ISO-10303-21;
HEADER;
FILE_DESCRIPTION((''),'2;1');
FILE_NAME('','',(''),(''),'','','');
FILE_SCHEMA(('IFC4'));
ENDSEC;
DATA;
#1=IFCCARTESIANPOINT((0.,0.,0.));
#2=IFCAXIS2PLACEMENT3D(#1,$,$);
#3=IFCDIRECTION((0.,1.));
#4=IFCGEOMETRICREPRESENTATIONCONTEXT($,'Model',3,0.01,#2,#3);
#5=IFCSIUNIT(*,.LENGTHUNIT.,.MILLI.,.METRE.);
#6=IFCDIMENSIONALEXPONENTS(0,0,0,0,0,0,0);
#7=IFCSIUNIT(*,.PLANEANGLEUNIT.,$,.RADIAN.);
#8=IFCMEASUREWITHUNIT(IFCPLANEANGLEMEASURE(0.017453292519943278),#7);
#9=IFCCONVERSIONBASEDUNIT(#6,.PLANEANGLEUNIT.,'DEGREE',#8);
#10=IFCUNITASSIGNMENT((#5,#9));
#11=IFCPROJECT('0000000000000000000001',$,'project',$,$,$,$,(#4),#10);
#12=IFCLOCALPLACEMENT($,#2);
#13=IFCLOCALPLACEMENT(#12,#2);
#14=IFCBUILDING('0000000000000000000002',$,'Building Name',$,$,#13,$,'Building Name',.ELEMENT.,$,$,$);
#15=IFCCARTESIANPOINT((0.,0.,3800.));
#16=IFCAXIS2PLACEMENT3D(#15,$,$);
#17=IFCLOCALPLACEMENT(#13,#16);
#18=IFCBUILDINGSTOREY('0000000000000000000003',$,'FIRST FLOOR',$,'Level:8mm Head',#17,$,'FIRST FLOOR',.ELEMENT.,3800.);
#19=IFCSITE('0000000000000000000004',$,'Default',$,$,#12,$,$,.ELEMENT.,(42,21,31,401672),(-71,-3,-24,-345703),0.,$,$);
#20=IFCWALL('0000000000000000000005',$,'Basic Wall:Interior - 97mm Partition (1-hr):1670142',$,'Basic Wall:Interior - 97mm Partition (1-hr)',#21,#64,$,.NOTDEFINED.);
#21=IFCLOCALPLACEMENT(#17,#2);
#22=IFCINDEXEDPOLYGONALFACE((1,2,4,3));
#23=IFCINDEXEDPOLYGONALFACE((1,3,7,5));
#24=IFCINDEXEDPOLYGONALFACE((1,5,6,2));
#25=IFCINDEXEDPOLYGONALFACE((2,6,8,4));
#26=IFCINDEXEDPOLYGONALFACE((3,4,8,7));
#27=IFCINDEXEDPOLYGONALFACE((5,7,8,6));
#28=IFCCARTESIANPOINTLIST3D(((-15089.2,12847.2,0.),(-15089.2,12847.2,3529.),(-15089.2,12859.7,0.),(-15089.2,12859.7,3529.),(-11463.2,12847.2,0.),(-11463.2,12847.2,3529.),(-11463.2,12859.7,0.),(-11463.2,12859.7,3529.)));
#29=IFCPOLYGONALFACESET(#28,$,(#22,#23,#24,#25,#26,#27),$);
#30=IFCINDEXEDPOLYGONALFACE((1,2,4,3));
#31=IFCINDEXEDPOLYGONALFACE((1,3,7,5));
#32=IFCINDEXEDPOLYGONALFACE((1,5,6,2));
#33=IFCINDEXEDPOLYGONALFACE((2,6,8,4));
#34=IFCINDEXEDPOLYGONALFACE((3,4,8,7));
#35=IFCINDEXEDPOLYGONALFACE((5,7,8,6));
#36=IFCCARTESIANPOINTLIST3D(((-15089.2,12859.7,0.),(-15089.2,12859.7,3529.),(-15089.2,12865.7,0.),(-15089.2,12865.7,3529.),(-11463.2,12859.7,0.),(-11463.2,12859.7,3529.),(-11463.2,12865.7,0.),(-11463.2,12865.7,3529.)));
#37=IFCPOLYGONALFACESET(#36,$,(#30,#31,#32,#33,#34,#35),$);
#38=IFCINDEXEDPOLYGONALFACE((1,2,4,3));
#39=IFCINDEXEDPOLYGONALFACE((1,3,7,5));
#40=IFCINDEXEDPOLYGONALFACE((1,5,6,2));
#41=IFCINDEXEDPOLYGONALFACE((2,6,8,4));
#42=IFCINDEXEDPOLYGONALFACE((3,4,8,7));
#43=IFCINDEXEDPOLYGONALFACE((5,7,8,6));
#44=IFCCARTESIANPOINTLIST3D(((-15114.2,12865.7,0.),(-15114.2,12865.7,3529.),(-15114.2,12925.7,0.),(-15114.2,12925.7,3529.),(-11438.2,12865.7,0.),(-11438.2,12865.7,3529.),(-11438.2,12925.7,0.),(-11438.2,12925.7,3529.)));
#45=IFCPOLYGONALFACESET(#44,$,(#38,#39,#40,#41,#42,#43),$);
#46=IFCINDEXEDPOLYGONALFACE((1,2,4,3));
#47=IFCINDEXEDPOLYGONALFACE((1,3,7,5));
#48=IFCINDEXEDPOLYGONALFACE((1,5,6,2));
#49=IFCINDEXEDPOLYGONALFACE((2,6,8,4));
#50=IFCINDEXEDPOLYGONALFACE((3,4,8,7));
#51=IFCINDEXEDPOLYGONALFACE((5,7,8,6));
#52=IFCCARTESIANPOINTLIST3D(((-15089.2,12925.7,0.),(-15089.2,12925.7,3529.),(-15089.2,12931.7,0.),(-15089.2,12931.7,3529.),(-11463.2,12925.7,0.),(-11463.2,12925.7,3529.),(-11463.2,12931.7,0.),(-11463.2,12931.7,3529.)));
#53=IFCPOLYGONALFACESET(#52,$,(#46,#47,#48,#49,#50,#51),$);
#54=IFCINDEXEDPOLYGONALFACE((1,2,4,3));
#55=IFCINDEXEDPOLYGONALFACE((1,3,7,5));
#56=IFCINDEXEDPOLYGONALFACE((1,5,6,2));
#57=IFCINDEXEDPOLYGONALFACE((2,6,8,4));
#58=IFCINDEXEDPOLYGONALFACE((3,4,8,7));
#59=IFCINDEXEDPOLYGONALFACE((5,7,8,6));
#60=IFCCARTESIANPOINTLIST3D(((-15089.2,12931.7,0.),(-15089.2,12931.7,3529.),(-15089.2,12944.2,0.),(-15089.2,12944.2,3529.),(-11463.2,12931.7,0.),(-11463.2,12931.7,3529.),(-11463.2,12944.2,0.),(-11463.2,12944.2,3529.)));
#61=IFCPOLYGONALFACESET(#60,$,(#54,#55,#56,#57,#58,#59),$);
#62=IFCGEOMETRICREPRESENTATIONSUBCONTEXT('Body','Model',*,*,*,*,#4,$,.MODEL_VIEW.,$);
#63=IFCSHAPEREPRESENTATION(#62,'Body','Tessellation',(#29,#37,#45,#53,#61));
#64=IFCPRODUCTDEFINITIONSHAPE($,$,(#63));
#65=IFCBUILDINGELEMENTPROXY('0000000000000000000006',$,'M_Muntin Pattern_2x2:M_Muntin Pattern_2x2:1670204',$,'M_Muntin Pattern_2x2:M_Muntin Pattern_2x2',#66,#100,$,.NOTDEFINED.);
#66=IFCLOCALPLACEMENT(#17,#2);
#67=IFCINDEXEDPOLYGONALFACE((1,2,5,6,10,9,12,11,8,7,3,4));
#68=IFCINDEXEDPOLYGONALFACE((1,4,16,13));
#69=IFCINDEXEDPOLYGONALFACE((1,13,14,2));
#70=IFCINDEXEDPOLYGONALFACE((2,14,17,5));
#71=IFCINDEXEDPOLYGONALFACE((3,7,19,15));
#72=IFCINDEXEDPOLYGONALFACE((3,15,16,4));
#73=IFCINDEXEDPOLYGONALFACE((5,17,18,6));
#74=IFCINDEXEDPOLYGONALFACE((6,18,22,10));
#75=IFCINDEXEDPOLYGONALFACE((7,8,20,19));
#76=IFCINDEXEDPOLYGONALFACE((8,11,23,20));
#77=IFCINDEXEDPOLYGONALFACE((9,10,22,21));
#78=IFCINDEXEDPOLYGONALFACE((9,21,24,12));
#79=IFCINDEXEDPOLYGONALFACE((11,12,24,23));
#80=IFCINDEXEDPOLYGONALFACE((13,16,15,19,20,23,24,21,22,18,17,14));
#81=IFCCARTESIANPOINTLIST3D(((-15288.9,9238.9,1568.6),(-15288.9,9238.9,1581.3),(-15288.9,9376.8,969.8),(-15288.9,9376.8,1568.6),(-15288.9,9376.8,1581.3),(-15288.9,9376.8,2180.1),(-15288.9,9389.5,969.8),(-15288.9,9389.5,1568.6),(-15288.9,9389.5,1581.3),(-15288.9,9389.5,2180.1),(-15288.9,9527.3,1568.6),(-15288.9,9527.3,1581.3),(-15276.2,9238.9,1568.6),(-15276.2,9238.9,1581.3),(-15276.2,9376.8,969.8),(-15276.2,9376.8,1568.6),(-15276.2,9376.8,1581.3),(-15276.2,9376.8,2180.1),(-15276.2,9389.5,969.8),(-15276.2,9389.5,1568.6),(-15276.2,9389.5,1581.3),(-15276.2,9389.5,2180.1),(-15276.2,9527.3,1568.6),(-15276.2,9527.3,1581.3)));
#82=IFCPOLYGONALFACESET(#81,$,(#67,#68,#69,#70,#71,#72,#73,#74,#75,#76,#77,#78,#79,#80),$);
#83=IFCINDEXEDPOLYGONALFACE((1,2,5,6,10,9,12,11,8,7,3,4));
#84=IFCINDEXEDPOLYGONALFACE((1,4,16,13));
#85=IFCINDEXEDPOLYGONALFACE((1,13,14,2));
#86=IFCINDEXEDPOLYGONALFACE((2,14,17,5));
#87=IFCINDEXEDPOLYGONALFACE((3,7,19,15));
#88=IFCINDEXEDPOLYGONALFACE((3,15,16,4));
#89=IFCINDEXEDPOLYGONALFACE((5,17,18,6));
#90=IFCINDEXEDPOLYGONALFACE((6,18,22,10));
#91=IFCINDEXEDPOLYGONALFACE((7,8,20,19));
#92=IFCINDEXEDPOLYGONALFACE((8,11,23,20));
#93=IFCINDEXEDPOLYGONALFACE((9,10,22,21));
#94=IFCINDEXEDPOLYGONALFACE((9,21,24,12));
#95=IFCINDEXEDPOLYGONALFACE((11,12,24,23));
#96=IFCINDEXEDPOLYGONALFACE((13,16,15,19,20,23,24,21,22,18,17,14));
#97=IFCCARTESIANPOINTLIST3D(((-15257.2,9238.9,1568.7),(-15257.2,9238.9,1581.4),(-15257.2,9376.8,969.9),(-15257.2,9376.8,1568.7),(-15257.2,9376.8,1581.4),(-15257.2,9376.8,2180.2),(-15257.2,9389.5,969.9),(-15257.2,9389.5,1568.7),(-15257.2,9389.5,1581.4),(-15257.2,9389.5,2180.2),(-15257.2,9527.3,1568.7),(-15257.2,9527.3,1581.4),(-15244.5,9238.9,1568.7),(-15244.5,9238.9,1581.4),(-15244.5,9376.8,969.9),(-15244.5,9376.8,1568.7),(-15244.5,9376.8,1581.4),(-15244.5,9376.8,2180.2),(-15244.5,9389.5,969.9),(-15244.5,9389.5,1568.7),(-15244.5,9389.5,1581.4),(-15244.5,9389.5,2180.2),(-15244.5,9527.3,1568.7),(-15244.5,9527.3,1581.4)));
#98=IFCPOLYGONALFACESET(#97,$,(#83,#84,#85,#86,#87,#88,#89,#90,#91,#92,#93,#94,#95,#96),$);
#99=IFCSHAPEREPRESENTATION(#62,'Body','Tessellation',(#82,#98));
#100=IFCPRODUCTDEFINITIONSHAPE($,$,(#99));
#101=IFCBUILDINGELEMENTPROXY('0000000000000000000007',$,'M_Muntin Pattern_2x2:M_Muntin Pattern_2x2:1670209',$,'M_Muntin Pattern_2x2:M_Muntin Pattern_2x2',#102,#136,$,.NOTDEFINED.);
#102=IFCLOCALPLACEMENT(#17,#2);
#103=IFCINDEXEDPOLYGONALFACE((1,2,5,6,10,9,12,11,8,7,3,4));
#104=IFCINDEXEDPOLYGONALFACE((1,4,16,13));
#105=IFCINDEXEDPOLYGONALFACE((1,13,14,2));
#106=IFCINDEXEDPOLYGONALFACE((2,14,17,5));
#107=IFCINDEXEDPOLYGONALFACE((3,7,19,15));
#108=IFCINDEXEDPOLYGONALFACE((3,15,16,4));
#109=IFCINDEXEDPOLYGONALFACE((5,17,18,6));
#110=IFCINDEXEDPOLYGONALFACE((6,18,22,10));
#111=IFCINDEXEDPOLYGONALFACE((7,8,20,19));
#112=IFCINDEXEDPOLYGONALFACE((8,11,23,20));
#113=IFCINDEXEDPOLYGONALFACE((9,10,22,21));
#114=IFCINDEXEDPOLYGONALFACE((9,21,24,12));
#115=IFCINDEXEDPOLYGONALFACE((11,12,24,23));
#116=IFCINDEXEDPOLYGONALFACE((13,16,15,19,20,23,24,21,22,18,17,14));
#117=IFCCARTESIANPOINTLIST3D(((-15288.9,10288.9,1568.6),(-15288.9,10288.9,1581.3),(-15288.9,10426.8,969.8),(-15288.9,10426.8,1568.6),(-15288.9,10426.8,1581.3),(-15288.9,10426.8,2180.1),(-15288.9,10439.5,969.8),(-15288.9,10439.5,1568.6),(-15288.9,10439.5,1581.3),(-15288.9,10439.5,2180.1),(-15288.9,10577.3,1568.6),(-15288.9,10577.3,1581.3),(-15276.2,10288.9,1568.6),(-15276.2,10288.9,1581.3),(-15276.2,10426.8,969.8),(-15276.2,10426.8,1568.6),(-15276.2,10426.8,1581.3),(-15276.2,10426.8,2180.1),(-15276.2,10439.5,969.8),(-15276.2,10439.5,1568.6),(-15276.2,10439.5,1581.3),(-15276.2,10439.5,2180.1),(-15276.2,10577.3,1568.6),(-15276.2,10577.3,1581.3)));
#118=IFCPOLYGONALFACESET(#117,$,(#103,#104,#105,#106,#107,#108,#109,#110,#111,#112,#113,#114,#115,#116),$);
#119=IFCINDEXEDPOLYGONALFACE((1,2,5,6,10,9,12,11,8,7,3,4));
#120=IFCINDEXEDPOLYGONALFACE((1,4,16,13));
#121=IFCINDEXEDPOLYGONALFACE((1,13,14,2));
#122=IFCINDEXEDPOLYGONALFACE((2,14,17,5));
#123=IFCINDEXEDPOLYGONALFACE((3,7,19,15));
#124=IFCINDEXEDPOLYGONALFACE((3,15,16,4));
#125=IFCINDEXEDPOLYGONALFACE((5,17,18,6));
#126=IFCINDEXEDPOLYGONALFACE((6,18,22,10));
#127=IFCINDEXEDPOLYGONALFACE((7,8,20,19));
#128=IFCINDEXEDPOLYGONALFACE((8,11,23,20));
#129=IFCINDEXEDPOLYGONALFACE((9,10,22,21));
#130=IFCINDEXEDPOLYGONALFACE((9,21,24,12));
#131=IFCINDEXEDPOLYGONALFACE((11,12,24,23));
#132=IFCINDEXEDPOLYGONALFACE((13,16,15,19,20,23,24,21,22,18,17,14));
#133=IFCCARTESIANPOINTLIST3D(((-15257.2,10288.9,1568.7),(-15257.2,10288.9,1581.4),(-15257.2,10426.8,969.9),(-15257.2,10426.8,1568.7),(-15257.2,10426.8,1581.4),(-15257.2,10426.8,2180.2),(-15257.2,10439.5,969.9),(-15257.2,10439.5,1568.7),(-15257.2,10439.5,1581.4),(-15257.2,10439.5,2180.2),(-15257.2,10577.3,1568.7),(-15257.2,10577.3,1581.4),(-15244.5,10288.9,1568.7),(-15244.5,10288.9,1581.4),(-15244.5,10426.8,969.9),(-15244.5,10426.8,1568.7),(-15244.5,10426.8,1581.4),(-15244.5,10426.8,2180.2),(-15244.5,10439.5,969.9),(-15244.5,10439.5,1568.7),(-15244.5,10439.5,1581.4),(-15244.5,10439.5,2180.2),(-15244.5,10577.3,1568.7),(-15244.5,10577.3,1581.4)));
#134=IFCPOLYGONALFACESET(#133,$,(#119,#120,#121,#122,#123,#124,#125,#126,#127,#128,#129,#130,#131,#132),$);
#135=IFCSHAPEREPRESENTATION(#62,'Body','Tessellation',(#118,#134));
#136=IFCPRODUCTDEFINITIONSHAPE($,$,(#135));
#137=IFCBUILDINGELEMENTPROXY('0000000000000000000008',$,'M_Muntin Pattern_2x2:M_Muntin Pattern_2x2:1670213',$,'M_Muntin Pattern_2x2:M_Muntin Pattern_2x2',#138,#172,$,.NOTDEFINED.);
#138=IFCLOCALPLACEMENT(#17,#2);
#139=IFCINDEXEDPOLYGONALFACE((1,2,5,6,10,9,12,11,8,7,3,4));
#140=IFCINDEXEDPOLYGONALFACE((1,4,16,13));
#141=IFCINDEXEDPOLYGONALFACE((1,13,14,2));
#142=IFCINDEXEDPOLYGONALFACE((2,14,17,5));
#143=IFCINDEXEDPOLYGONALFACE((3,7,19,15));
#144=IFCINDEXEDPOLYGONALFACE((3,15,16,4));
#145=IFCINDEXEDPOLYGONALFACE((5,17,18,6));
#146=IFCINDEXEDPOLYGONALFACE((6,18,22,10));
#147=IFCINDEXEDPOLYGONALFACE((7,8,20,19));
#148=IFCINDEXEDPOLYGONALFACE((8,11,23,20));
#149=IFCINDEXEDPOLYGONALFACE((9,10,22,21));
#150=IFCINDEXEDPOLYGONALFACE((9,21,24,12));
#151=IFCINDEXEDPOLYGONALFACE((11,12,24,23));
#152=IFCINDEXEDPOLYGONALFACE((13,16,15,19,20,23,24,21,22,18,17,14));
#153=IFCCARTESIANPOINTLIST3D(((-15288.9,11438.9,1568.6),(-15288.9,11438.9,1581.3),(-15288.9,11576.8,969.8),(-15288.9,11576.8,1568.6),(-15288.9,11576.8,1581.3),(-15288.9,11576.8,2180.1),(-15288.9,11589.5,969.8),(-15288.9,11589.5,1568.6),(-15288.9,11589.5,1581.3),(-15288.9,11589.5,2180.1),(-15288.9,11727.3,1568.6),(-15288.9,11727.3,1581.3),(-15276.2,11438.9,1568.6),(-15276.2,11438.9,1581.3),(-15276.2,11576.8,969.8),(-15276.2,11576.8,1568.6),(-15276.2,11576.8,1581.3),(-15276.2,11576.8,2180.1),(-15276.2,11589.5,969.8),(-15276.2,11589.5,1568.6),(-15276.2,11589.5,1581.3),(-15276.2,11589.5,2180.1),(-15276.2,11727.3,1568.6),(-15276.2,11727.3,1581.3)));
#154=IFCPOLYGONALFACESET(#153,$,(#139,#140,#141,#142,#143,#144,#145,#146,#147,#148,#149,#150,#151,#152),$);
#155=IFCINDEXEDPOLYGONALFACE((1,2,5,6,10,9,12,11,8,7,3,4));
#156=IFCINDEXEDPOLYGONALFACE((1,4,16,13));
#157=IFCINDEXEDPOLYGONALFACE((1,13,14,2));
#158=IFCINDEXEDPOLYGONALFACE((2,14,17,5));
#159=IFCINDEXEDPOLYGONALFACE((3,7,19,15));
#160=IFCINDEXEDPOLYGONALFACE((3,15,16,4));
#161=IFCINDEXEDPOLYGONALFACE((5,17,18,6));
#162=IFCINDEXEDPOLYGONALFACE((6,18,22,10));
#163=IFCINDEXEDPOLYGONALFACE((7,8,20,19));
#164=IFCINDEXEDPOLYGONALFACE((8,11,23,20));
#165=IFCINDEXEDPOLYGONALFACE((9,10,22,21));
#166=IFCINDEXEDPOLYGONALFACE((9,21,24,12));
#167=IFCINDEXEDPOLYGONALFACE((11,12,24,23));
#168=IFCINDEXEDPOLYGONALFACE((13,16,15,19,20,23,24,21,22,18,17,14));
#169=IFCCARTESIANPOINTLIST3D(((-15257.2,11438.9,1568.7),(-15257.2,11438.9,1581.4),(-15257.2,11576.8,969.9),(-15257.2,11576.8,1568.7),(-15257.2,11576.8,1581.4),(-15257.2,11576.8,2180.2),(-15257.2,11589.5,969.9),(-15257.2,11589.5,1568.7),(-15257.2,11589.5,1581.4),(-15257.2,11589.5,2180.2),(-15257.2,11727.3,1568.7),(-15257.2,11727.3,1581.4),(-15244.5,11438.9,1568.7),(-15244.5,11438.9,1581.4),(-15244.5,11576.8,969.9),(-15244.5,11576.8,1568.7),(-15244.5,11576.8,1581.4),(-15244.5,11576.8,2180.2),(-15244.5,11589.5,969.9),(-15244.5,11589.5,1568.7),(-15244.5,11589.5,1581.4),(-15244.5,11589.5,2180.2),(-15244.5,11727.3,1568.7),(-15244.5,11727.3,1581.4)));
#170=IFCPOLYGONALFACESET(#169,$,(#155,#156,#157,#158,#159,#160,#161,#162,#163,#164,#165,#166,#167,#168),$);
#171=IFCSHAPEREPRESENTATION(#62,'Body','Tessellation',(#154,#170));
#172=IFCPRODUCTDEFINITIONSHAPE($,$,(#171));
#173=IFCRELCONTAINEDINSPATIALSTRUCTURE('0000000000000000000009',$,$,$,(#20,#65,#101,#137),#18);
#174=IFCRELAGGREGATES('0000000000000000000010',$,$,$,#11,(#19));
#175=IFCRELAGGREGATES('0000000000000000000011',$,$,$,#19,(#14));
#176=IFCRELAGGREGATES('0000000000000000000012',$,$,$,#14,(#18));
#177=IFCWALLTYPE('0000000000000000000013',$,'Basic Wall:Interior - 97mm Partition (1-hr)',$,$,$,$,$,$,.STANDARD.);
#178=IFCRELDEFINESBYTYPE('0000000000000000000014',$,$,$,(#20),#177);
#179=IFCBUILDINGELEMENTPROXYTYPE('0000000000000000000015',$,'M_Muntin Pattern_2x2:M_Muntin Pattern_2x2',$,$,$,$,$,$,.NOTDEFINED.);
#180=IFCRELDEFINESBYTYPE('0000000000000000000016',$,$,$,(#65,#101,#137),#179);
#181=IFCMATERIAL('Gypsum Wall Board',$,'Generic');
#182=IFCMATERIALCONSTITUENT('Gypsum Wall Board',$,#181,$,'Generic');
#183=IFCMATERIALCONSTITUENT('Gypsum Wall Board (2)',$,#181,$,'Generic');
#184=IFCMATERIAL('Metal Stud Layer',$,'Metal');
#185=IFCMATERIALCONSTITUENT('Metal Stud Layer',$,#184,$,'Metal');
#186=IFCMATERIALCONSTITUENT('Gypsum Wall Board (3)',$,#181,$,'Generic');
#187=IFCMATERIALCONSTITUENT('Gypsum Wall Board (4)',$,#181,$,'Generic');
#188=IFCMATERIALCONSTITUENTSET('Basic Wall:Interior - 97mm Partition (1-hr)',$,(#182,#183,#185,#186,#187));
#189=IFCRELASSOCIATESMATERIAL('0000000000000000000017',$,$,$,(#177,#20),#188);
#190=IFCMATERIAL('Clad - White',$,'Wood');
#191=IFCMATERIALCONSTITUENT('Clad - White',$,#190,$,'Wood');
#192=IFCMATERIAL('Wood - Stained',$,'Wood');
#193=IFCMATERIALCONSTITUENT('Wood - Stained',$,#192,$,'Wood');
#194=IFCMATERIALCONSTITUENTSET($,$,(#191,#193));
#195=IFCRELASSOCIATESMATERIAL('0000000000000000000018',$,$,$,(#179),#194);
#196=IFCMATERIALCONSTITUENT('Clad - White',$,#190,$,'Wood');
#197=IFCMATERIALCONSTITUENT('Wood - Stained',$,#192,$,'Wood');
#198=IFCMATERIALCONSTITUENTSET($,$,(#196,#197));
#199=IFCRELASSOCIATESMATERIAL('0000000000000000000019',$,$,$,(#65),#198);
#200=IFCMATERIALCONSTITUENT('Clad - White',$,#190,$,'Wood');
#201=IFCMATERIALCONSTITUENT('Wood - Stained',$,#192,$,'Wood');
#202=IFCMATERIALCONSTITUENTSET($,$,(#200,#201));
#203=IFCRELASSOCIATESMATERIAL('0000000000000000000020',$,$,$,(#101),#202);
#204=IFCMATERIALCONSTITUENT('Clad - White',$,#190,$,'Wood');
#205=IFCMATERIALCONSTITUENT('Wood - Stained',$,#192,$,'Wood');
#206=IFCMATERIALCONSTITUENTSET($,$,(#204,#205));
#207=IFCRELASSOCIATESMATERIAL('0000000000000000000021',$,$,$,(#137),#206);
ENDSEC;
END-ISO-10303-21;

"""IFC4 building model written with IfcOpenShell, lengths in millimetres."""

from ifc_helpers import new_model, entity, si_unit, converted_unit, direction, frame, origin, place, context, subcontext, project, spatial, indexed_curve, outline, extrude, source, transform, mapped, material, constituent, constituent_set, type_object, type_shapes, element, save


model = new_model("IFC4")

# Units and contexts
model_context = context("Model", 3, precision=0.01, world=origin(), true_north=direction((0.0, 1.0)))
body_context = subcontext(model_context, "Body", "Model", "MODEL_VIEW")
ifc_project = project(units=[si_unit("LENGTHUNIT", "METRE", prefix="MILLI"), converted_unit("PLANEANGLEUNIT", "DEGREE", entity("IfcPlaneAngleMeasure", 0.017453292519943278), si_unit("PLANEANGLEUNIT", "RADIAN"), dimensions=[0, 0, 0, 0, 0, 0, 0])], contexts=[model_context])

# Site, building, storey
site_placement = place(None, origin())
site = spatial("IfcSite", under=ifc_project, at=site_placement, Name="Default", CompositionType="ELEMENT", RefLatitude=(42, 21, 31, 401672), RefLongitude=(-71, -3, -24, -345703), RefElevation=0.0)
building_placement = place(site_placement, origin())
building = spatial("IfcBuilding", under=site, at=building_placement, Name="Building Name", LongName="Building Name", CompositionType="ELEMENT")
storey_placement = place(building_placement, frame((0.0, 0.0, 3800.0)))
storey = spatial("IfcBuildingStorey", under=building, at=storey_placement, Name="FIRST FLOOR", ObjectType="Level:8mm Head", LongName="FIRST FLOOR", CompositionType="ELEMENT", Elevation=3800.0)

# Shared definitions
ifc_material_1 = material(Name="Wood - Stained", Category="Wood")

# Wall
ifc_material_2 = material(Name="Gypsum Wall Board", Category="Generic")
ifc_constituent_1 = constituent(ifc_material_2, Name="Gypsum Wall Board", Category="Generic")
ifc_constituent_2 = constituent(ifc_material_2, Name="Gypsum Wall Board (2)", Category="Generic")
ifc_material_3 = material(Name="Metal Stud Layer", Category="Metal")
ifc_constituent_3 = constituent(ifc_material_3, Name="Metal Stud Layer", Category="Metal")
ifc_constituent_4 = constituent(ifc_material_2, Name="Gypsum Wall Board (3)", Category="Generic")
ifc_constituent_5 = constituent(ifc_material_2, Name="Gypsum Wall Board (4)", Category="Generic")
ifc_constituent_set_1 = constituent_set(constituents=[ifc_constituent_1, ifc_constituent_2, ifc_constituent_3, ifc_constituent_4, ifc_constituent_5], Name="Basic Wall:Interior - 97mm Partition (1-hr)")
wall_type_1 = type_object("IfcWallType", Name="Basic Wall:Interior - 97mm Partition (1-hr)", PredefinedType="STANDARD", material=ifc_constituent_set_1)
wall_1_placement = place(storey_placement, frame((-15089.2, 12895.7, 0.0)))
element("IfcWall", 1, at=wall_1_placement, inside=storey, type_object=wall_type_1, material=ifc_constituent_set_1, Name="Basic Wall:Interior - 97mm Partition (1-hr):1670142", ObjectType="Basic Wall:Interior - 97mm Partition (1-hr)", PredefinedType="NOTDEFINED", context=body_context, shape_type="SweptSolid", body=[
    extrude(outline(indexed_curve([(-6.3, -1813.0), (6.2, -1813.0), (6.3, 1813.0), (-6.2, 1813.0), (-6.3, -1813.0)], self_intersect=False)), frame((1813.0, -42.2, 0.0), z_axis=(0.0, 0.0, 1.0), x_axis=(0.0, 1.0, 0.0)), (0.0, 0.0, 1.0), 3529.0),
    extrude(outline(indexed_curve([(-1813.0, -3.0), (1813.0, -3.0), (1813.0, 3.0), (-1813.0, 3.0), (-1813.0, -3.0)], self_intersect=False)), frame((1813.0, -33.0, 0.0)), (0.0, 0.0, 1.0), 3529.0),
    extrude(outline(indexed_curve([(-1838.0, -30.0), (1838.0, -30.0), (1838.0, 30.0), (-1838.0, 30.0), (-1838.0, -30.0)], self_intersect=False)), frame((1813.0, 0.0, 0.0)), (0.0, 0.0, 1.0), 3529.0),
    extrude(outline(indexed_curve([(-1813.0, -3.0), (1813.0, -3.0), (1813.0, 3.0), (-1813.0, 3.0), (-1813.0, -3.0)], self_intersect=False)), frame((1813.0, 33.0, 0.0)), (0.0, 0.0, 1.0), 3529.0),
    extrude(outline(indexed_curve([(-6.3, -1813.0), (6.2, -1813.0), (6.3, 1813.0), (-6.2, 1813.0), (-6.3, -1813.0)], self_intersect=False)), frame((1813.0, 42.2, 0.0), z_axis=(0.0, 0.0, 1.0), x_axis=(0.0, -1.0, 0.0)), (0.0, 0.0, 1.0), 3529.0),
])

# Building element proxies
ifc_material_4 = material(Name="Clad - White", Category="Wood")
ifc_constituent_6 = constituent(ifc_material_4, Name="Clad - White", Category="Wood")
ifc_constituent_7 = constituent(ifc_material_1, Name="Wood - Stained", Category="Wood")
ifc_constituent_set_2 = constituent_set(constituents=[ifc_constituent_6, ifc_constituent_7])
ifc_constituent_8 = constituent(ifc_material_4, Name="Clad - White", Category="Wood")
ifc_constituent_9 = constituent(ifc_material_1, Name="Wood - Stained", Category="Wood")
ifc_constituent_set_3 = constituent_set(constituents=[ifc_constituent_8, ifc_constituent_9])
building_element_proxy_type_1 = type_object("IfcBuildingElementProxyType", Name="M_Muntin Pattern_2x2:M_Muntin Pattern_2x2", PredefinedType="NOTDEFINED", material=ifc_constituent_set_3)
shared_shape_1 = source(origin(), body_context, "Body", "SweptSolid", [
    extrude(outline(indexed_curve([(6.4, -6.4), (605.1, -6.4), (605.1, 6.3), (6.4, 6.3), (6.4, 144.2), (-6.3, 144.2), (-6.3, 6.3), (-605.2, 6.3), (-605.2, -6.4), (-6.3, -6.4), (-6.3, -144.2), (6.4, -144.2), (6.4, -6.4)], self_intersect=False)), frame((0.0, -22.2, 605.1), z_axis=(0.0, 1.0, 0.0), x_axis=(0.0, 0.0, 1.0)), (0.0, 0.0, 1.0), 12.7),
    extrude(outline(indexed_curve([(6.4, -6.4), (605.2, -6.4), (605.2, 6.3), (6.4, 6.3), (6.4, 144.2), (-6.3, 144.2), (-6.3, 6.3), (-605.2, 6.3), (-605.2, -6.4), (-6.3, -6.4), (-6.3, -144.2), (6.4, -144.2), (6.4, -6.4)], self_intersect=False)), frame((0.0, 9.5, 605.2), z_axis=(0.0, 1.0, 0.0), x_axis=(0.0, 0.0, 1.0)), (0.0, 0.0, 1.0), 12.7),
])
type_shapes(building_element_proxy_type_1, [shared_shape_1])
proxy_1_placement = place(storey_placement, frame((-15266.7, 9383.1, 969.9), z_axis=(0.0, 0.0, 1.0), x_axis=(0.0, -1.0, 0.0)))
element("IfcBuildingElementProxy", 2, at=proxy_1_placement, inside=storey, type_object=building_element_proxy_type_1, material=ifc_constituent_set_2, Name="M_Muntin Pattern_2x2:M_Muntin Pattern_2x2:1670204", ObjectType="M_Muntin Pattern_2x2:M_Muntin Pattern_2x2", PredefinedType="NOTDEFINED", context=body_context, shape_type="MappedRepresentation", body=[
    mapped(shared_shape_1, transform((0.0, 0.0, 0.0), scale=1.0)),
])
ifc_constituent_10 = constituent(ifc_material_4, Name="Clad - White", Category="Wood")
ifc_constituent_11 = constituent(ifc_material_1, Name="Wood - Stained", Category="Wood")
ifc_constituent_set_4 = constituent_set(constituents=[ifc_constituent_10, ifc_constituent_11])
proxy_2_placement = place(storey_placement, frame((-15266.7, 10433.1, 969.9), z_axis=(0.0, 0.0, 1.0), x_axis=(0.0, -1.0, 0.0)))
element("IfcBuildingElementProxy", 3, at=proxy_2_placement, inside=storey, type_object=building_element_proxy_type_1, material=ifc_constituent_set_4, Name="M_Muntin Pattern_2x2:M_Muntin Pattern_2x2:1670209", ObjectType="M_Muntin Pattern_2x2:M_Muntin Pattern_2x2", PredefinedType="NOTDEFINED", context=body_context, shape_type="MappedRepresentation", body=[
    mapped(shared_shape_1, transform((0.0, 0.0, 0.0), scale=1.0)),
])
ifc_constituent_12 = constituent(ifc_material_4, Name="Clad - White", Category="Wood")
ifc_constituent_13 = constituent(ifc_material_1, Name="Wood - Stained", Category="Wood")
ifc_constituent_set_5 = constituent_set(constituents=[ifc_constituent_12, ifc_constituent_13])
proxy_3_placement = place(storey_placement, frame((-15266.7, 11583.1, 969.9), z_axis=(0.0, 0.0, 1.0), x_axis=(0.0, -1.0, 0.0)))
element("IfcBuildingElementProxy", 4, at=proxy_3_placement, inside=storey, type_object=building_element_proxy_type_1, material=ifc_constituent_set_5, Name="M_Muntin Pattern_2x2:M_Muntin Pattern_2x2:1670213", ObjectType="M_Muntin Pattern_2x2:M_Muntin Pattern_2x2", PredefinedType="NOTDEFINED", context=body_context, shape_type="MappedRepresentation", body=[
    mapped(shared_shape_1, transform((0.0, 0.0, 0.0), scale=1.0)),
])

save(model, "model.ifc")
